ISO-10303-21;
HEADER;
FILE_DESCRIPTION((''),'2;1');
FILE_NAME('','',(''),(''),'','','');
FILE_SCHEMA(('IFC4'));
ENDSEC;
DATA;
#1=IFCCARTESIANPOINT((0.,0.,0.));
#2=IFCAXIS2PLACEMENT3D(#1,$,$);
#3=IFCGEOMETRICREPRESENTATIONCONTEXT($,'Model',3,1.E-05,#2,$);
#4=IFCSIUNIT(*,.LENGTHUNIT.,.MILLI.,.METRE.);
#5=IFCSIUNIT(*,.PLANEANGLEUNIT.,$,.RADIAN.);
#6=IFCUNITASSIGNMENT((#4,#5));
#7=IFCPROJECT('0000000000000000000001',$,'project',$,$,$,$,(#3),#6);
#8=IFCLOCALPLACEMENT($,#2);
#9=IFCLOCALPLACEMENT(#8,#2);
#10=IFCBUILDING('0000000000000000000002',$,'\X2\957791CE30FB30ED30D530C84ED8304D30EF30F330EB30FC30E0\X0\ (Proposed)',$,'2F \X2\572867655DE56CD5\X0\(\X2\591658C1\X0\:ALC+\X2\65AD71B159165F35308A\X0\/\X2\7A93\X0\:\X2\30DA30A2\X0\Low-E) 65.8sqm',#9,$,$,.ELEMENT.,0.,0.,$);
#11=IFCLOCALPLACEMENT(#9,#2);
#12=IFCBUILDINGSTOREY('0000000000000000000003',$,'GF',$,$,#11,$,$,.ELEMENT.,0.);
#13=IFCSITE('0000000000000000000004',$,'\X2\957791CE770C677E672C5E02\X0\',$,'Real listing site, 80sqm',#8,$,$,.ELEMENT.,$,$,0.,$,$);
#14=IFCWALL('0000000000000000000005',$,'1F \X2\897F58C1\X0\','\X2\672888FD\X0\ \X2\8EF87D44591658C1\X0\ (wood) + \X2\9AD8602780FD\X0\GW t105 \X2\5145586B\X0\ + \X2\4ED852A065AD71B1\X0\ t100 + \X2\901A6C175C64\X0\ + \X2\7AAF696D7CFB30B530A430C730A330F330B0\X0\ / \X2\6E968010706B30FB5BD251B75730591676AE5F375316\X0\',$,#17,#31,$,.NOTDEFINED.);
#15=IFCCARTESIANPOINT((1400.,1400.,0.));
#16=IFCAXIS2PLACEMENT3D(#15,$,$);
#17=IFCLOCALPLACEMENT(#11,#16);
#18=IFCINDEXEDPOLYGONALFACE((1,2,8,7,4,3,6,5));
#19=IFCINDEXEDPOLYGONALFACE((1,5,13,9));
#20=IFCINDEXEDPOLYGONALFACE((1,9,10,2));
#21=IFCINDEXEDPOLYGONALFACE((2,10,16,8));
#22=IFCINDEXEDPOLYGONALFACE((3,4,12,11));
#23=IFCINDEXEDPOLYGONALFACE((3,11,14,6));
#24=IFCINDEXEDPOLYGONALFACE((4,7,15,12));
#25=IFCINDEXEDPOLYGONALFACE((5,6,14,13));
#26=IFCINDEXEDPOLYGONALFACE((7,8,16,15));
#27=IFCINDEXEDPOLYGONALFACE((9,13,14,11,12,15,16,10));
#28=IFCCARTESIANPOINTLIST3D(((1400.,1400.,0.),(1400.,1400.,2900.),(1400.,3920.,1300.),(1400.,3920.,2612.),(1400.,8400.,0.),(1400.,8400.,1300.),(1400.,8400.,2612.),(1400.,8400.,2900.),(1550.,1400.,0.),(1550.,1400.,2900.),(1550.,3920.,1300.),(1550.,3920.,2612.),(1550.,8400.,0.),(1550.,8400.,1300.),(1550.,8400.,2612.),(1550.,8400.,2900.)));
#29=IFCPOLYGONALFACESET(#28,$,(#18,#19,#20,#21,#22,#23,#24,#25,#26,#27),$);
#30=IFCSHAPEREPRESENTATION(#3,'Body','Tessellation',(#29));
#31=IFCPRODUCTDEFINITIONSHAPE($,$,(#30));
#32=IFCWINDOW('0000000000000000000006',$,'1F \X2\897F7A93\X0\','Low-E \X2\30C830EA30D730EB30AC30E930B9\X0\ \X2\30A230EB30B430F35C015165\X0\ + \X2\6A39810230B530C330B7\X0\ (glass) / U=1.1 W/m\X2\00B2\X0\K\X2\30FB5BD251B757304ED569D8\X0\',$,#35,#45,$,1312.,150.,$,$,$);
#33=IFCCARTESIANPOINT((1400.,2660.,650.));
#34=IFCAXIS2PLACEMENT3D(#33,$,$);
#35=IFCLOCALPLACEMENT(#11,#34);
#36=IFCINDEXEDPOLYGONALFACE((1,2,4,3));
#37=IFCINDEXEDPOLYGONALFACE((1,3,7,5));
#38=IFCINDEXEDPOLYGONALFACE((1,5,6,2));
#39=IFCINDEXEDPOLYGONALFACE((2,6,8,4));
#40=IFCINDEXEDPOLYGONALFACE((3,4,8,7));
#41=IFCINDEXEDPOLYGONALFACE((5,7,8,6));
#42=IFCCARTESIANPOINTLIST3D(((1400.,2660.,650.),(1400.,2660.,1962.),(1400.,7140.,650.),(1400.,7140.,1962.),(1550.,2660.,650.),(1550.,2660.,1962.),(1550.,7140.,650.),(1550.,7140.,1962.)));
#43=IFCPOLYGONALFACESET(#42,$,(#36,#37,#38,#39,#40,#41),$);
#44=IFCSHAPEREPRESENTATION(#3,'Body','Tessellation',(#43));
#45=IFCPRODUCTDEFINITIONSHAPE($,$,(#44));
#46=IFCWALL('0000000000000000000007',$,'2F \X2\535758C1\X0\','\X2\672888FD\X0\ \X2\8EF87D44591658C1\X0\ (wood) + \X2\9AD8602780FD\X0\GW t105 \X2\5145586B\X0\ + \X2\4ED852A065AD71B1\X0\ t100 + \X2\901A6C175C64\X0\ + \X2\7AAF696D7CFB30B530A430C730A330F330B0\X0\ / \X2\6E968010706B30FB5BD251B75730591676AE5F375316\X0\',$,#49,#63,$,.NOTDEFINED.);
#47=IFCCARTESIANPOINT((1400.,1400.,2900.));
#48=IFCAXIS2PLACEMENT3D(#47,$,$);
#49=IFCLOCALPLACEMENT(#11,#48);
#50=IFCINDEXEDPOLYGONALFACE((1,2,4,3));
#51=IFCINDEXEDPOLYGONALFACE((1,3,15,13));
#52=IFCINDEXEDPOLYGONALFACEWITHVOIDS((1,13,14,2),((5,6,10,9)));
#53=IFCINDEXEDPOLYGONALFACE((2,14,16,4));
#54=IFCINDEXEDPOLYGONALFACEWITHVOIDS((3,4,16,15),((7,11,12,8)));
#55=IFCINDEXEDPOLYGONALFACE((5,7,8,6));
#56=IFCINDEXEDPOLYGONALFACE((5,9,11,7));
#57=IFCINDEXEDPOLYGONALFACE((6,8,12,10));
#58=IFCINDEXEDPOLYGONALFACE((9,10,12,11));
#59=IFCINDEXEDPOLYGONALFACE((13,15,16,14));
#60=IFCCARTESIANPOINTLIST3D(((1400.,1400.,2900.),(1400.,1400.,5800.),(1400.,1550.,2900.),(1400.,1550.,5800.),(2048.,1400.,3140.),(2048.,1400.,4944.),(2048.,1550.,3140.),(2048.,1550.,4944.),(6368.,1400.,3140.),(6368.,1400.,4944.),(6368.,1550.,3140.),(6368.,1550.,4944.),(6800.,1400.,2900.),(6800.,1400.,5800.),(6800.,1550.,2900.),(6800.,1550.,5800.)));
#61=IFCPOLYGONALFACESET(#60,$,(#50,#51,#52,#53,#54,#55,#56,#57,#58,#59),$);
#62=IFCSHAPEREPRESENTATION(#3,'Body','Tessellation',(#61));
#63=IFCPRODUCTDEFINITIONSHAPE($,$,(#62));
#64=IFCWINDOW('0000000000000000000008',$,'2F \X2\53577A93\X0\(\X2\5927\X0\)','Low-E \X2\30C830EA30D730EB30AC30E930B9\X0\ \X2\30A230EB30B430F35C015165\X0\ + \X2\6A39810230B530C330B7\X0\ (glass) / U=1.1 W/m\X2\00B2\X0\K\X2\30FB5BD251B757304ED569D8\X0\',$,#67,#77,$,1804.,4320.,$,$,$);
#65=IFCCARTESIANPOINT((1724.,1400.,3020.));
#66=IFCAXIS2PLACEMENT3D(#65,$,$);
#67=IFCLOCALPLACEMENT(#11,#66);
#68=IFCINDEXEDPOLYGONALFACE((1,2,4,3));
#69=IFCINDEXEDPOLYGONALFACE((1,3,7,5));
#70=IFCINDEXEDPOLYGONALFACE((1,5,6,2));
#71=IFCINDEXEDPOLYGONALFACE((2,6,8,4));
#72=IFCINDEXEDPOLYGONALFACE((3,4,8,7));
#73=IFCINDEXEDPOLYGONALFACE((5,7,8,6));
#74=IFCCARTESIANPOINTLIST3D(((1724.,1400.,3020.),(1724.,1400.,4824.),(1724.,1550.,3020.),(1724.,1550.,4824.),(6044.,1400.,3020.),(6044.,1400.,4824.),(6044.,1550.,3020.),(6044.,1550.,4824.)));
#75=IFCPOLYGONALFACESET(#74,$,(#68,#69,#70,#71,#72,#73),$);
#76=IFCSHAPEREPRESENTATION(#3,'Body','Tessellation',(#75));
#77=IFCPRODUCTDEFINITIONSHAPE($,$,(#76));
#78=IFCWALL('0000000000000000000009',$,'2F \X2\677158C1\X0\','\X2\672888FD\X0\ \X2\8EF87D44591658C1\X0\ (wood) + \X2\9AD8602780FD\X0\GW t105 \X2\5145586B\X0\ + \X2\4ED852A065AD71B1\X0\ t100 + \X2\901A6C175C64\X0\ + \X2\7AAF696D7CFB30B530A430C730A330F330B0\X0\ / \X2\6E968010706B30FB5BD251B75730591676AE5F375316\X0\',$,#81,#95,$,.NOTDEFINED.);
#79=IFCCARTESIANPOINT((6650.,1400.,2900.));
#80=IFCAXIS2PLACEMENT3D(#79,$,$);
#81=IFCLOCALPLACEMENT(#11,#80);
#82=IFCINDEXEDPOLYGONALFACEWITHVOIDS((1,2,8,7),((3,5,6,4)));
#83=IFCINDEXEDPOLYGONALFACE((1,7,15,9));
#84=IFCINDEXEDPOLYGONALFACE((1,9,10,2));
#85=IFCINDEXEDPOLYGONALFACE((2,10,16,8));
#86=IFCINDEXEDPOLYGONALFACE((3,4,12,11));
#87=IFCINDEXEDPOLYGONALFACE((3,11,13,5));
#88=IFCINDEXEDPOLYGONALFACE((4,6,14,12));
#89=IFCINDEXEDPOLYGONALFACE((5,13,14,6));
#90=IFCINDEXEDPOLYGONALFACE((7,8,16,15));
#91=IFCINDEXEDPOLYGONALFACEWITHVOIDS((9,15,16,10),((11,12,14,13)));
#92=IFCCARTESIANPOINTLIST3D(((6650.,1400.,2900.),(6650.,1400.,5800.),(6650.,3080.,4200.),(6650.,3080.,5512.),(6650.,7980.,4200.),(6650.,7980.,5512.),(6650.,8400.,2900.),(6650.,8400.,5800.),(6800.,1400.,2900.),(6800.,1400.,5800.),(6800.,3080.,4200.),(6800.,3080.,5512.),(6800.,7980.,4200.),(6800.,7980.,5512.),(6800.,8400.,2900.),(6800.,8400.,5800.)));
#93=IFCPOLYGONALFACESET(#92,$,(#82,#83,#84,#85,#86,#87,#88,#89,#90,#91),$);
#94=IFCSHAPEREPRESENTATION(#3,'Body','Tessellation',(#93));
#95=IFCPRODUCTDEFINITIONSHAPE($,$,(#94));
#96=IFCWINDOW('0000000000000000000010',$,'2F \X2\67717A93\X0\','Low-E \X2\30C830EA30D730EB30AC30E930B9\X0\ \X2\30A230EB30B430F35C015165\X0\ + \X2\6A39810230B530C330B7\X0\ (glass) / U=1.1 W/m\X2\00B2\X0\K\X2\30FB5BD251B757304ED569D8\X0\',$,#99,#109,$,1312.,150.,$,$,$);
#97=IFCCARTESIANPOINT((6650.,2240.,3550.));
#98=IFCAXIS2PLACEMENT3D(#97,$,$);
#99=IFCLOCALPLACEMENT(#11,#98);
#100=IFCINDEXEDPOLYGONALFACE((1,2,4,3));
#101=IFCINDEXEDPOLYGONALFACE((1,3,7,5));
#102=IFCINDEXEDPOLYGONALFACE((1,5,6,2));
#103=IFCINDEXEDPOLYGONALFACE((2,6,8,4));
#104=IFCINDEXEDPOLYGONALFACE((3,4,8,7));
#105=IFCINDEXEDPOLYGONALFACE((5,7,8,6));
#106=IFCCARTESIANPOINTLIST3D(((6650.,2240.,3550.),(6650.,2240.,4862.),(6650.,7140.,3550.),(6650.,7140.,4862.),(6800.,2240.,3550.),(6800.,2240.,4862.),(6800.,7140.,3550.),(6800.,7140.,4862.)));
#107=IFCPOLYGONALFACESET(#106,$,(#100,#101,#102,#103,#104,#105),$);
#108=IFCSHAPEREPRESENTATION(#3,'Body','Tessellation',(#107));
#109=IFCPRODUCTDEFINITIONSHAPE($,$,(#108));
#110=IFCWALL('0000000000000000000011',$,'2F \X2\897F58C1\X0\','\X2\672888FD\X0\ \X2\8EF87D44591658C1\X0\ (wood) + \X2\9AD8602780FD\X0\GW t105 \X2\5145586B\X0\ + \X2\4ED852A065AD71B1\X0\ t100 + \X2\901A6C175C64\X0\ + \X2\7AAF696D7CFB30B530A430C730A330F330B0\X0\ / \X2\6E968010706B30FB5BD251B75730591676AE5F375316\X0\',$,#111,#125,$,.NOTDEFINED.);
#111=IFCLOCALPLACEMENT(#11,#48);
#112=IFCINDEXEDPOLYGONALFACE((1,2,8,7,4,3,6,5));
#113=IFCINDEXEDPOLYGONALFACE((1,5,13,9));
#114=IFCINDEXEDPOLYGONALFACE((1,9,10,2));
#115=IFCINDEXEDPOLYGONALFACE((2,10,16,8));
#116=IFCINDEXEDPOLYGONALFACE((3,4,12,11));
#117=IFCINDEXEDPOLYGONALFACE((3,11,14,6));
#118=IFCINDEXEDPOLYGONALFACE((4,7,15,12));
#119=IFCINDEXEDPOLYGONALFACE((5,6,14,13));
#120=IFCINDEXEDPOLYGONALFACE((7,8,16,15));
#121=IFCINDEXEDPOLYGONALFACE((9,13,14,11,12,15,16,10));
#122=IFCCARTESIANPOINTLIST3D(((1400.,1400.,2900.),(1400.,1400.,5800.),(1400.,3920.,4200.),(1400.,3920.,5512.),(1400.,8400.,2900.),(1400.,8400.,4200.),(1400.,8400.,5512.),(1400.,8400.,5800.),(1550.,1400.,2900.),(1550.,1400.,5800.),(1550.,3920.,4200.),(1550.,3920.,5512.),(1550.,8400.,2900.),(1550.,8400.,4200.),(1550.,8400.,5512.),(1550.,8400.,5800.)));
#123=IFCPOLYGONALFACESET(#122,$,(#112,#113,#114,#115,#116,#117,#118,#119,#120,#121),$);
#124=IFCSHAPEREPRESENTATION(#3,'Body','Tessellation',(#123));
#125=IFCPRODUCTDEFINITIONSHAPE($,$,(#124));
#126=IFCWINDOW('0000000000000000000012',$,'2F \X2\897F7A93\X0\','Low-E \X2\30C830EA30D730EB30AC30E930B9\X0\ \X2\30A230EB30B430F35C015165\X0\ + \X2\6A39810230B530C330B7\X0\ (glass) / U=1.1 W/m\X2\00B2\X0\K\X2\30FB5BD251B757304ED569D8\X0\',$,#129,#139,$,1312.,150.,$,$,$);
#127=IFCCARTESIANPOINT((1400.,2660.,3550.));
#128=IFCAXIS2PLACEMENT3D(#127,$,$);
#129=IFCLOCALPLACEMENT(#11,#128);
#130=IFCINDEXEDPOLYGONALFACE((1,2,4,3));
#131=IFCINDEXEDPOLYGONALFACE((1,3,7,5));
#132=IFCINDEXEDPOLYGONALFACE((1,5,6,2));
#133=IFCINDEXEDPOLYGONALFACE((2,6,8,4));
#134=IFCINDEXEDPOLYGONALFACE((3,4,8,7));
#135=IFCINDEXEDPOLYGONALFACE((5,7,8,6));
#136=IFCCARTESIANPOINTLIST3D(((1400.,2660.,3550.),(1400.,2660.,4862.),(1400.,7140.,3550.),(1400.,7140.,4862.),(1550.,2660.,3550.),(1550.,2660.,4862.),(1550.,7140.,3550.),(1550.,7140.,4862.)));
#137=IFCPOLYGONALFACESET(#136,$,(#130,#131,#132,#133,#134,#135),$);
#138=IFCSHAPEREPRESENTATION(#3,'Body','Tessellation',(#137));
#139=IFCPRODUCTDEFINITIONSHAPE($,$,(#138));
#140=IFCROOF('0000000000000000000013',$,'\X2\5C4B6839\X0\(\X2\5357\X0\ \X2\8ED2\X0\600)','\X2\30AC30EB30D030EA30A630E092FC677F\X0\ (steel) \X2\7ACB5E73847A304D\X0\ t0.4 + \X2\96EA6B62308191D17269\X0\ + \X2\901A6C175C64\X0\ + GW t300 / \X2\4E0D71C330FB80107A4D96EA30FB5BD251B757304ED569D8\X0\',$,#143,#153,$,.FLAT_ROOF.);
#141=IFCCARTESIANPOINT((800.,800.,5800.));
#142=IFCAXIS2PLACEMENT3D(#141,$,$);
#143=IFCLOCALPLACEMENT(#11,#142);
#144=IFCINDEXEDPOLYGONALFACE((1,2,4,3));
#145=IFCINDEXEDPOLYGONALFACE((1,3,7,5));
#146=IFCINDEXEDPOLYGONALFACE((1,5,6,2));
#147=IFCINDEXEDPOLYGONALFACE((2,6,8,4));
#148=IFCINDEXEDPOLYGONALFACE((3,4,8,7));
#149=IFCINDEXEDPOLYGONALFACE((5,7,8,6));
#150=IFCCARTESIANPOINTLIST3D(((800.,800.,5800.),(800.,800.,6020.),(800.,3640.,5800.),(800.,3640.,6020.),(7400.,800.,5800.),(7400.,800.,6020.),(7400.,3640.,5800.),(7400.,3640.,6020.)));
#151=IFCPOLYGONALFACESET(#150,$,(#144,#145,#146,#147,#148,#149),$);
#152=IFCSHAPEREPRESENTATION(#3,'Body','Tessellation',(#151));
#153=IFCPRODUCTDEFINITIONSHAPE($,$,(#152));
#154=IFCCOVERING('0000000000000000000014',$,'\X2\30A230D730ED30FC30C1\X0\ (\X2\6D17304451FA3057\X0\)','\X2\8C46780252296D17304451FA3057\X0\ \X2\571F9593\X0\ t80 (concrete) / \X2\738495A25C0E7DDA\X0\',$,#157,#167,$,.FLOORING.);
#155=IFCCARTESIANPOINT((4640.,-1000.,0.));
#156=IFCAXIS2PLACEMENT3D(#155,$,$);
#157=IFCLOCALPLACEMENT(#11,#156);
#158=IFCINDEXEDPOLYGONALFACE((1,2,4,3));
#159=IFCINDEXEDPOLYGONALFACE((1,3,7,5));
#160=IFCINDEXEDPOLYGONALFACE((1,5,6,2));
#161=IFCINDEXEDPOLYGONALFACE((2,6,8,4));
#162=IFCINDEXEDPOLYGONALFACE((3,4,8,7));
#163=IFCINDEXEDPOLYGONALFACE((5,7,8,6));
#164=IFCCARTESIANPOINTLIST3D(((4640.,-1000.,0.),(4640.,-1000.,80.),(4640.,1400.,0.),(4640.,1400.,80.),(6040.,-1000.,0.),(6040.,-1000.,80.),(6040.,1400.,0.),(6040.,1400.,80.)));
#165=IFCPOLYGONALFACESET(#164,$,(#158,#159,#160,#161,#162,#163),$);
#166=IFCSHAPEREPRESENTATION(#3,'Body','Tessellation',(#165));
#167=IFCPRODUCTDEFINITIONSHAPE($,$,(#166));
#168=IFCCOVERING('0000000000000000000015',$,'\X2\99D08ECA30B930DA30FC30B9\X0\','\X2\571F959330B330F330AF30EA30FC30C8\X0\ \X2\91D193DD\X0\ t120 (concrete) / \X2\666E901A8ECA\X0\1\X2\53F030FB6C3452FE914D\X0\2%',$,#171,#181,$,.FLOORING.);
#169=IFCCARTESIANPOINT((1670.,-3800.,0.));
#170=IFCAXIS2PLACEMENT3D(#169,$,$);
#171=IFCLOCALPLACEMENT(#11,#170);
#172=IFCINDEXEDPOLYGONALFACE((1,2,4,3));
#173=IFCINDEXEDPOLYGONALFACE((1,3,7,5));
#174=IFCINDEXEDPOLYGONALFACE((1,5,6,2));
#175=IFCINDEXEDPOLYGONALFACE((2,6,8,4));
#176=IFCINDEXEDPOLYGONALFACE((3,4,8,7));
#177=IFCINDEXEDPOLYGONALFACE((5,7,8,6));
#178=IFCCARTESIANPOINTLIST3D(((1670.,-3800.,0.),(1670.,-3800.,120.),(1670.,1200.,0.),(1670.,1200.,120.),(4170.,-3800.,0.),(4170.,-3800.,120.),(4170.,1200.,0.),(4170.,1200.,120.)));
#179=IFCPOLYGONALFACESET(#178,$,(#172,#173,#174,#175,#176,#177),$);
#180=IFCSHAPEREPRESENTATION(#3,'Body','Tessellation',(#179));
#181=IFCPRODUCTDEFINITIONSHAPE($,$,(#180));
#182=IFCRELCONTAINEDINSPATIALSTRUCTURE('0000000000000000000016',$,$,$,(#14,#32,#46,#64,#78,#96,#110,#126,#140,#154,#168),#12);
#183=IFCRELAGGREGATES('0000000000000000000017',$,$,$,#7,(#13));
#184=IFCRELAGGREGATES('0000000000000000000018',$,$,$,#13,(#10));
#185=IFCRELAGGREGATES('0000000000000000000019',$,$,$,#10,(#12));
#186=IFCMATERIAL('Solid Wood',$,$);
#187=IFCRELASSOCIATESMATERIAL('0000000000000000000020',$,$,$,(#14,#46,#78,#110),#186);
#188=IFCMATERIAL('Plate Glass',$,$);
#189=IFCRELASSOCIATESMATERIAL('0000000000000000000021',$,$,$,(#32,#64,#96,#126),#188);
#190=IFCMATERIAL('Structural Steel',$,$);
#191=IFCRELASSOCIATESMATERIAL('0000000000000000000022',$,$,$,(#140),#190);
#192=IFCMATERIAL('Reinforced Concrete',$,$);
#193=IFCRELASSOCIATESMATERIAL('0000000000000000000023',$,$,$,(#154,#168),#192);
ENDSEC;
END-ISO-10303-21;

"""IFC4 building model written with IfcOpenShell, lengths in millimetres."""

from ifc_helpers import new_model, si_unit, frame, frame_2d, origin, place, context, project, spatial, rectangle, extrude, material, element, fill, save


model = new_model("IFC4")

# Units and contexts
model_context = context("Model", 3, precision=1e-05, world=origin())
ifc_project = project(units=[si_unit("LENGTHUNIT", "METRE", prefix="MILLI"), si_unit("PLANEANGLEUNIT", "RADIAN")], contexts=[model_context])

# Site, building, storey
site_placement = place(None, origin())
site = spatial("IfcSite", under=ifc_project, at=site_placement, Name="長野県松本市", ObjectType="Real listing site, 80sqm", CompositionType="ELEMENT", RefElevation=0.0)
building_placement = place(site_placement, origin())
building = spatial("IfcBuilding", under=site, at=building_placement, Name="長野・ロフト付きワンルーム (Proposed)", ObjectType="2F 在来工法(外壁:ALC+断熱外張り/窓:ペアLow-E) 65.8sqm", CompositionType="ELEMENT", ElevationOfRefHeight=0.0, ElevationOfTerrain=0.0)
storey_placement = place(building_placement, origin())
storey = spatial("IfcBuildingStorey", under=building, at=storey_placement, Name="GF", CompositionType="ELEMENT", Elevation=0.0)

# Shared definitions
ifc_material_1 = material(Name="Solid Wood")

# Shared definitions
ifc_material_2 = material(Name="Reinforced Concrete")

# Shared definitions
ifc_material_3 = material(Name="Plate Glass")

# Walls, openings, windows
wall_1_placement = place(storey_placement, frame((1400.0, 1400.0, 0.0)))
wall_1 = element("IfcWall", 1, at=wall_1_placement, inside=storey, material=ifc_material_1, Name="1F 西壁", Description="木製 軸組外壁 (wood) + 高性能GW t105 充填 + 付加断熱 t100 + 通気層 + 窯業系サイディング / 準耐火・寒冷地外皮強化", PredefinedType="NOTDEFINED", context=model_context, shape_type="SweptSolid", body=[
    extrude(rectangle(XDim=150.0, YDim=7000.0, at=frame_2d((75.0, 3500.0))), frame((1400.0, 1400.0, 0.0)), (0.0, 0.0, 1.0), 2900.0),
])
opening_1_placement = place(storey_placement, frame((1400.0, 2660.0, 650.0)))
opening_1 = element("IfcOpeningElement", 2, at=opening_1_placement, cuts=wall_1, PredefinedType="NOTDEFINED", context=model_context, shape_type="SweptSolid", body=[
    extrude(rectangle(XDim=150.0, YDim=4480.0, at=frame_2d((75.0, 2240.0))), frame((1400.0, 2660.0, 650.0)), (0.0, 0.0, 1.0), 1312.0),
])
window_1_placement = place(storey_placement, frame((1400.0, 2660.0, 650.0)))
window_1 = element("IfcWindow", 3, at=window_1_placement, inside=storey, material=ifc_material_3, Name="1F 西窓", Description="Low-E トリプルガラス アルゴン封入 + 樹脂サッシ (glass) / U=1.1 W/m²K・寒冷地仕様", OverallHeight=1312.0, OverallWidth=150.0, context=model_context, shape_type="SweptSolid", body=[
    extrude(rectangle(XDim=150.0, YDim=4480.0, at=frame_2d((75.0, 2240.0))), frame((1400.0, 2660.0, 650.0)), (0.0, 0.0, 1.0), 1312.0),
])
fill(opening_1, window_1)
wall_2_placement = place(storey_placement, frame((1400.0, 1400.0, 2900.0)))
wall_2 = element("IfcWall", 4, at=wall_2_placement, inside=storey, material=ifc_material_1, Name="2F 南壁", Description="木製 軸組外壁 (wood) + 高性能GW t105 充填 + 付加断熱 t100 + 通気層 + 窯業系サイディング / 準耐火・寒冷地外皮強化", PredefinedType="NOTDEFINED", context=model_context, shape_type="SweptSolid", body=[
    extrude(rectangle(XDim=5400.0, YDim=150.0, at=frame_2d((2700.0, 75.0))), frame((1400.0, 1400.0, 2900.0)), (0.0, 0.0, 1.0), 2900.0),
])
opening_2_placement = place(storey_placement, frame((1724.0, 1400.0, 3020.0)))
opening_2 = element("IfcOpeningElement", 5, at=opening_2_placement, cuts=wall_2, PredefinedType="NOTDEFINED", context=model_context, shape_type="SweptSolid", body=[
    extrude(rectangle(XDim=4320.0, YDim=150.0, at=frame_2d((2160.0, 75.0))), frame((1724.0, 1400.0, 3020.0)), (0.0, 0.0, 1.0), 1804.0),
])
window_2_placement = place(storey_placement, frame((1724.0, 1400.0, 3020.0)))
window_2 = element("IfcWindow", 6, at=window_2_placement, inside=storey, material=ifc_material_3, Name="2F 南窓(大)", Description="Low-E トリプルガラス アルゴン封入 + 樹脂サッシ (glass) / U=1.1 W/m²K・寒冷地仕様", OverallHeight=1804.0, OverallWidth=4320.0, context=model_context, shape_type="SweptSolid", body=[
    extrude(rectangle(XDim=4320.0, YDim=150.0, at=frame_2d((2160.0, 75.0))), frame((1724.0, 1400.0, 3020.0)), (0.0, 0.0, 1.0), 1804.0),
])
fill(opening_2, window_2)
wall_3_placement = place(storey_placement, frame((6650.0, 1400.0, 2900.0)))
wall_3 = element("IfcWall", 7, at=wall_3_placement, inside=storey, material=ifc_material_1, Name="2F 東壁", Description="木製 軸組外壁 (wood) + 高性能GW t105 充填 + 付加断熱 t100 + 通気層 + 窯業系サイディング / 準耐火・寒冷地外皮強化", PredefinedType="NOTDEFINED", context=model_context, shape_type="SweptSolid", body=[
    extrude(rectangle(XDim=150.0, YDim=7000.0, at=frame_2d((75.0, 3500.0))), frame((6650.0, 1400.0, 2900.0)), (0.0, 0.0, 1.0), 2900.0),
])
opening_3_placement = place(storey_placement, frame((6650.0, 2240.0, 3550.0)))
opening_3 = element("IfcOpeningElement", 8, at=opening_3_placement, cuts=wall_3, PredefinedType="NOTDEFINED", context=model_context, shape_type="SweptSolid", body=[
    extrude(rectangle(XDim=150.0, YDim=4900.0, at=frame_2d((75.0, 2450.0))), frame((6650.0, 2240.0, 3550.0)), (0.0, 0.0, 1.0), 1312.0),
])
window_3_placement = place(storey_placement, frame((6650.0, 2240.0, 3550.0)))
window_3 = element("IfcWindow", 9, at=window_3_placement, inside=storey, material=ifc_material_3, Name="2F 東窓", Description="Low-E トリプルガラス アルゴン封入 + 樹脂サッシ (glass) / U=1.1 W/m²K・寒冷地仕様", OverallHeight=1312.0, OverallWidth=150.0, context=model_context, shape_type="SweptSolid", body=[
    extrude(rectangle(XDim=150.0, YDim=4900.0, at=frame_2d((75.0, 2450.0))), frame((6650.0, 2240.0, 3550.0)), (0.0, 0.0, 1.0), 1312.0),
])
fill(opening_3, window_3)
wall_4_placement = place(storey_placement, frame((1400.0, 1400.0, 2900.0)))
wall_4 = element("IfcWall", 10, at=wall_4_placement, inside=storey, material=ifc_material_1, Name="2F 西壁", Description="木製 軸組外壁 (wood) + 高性能GW t105 充填 + 付加断熱 t100 + 通気層 + 窯業系サイディング / 準耐火・寒冷地外皮強化", PredefinedType="NOTDEFINED", context=model_context, shape_type="SweptSolid", body=[
    extrude(rectangle(XDim=150.0, YDim=7000.0, at=frame_2d((75.0, 3500.0))), frame((1400.0, 1400.0, 2900.0)), (0.0, 0.0, 1.0), 2900.0),
])
opening_4_placement = place(storey_placement, frame((1400.0, 2660.0, 3550.0)))
opening_4 = element("IfcOpeningElement", 11, at=opening_4_placement, cuts=wall_4, PredefinedType="NOTDEFINED", context=model_context, shape_type="SweptSolid", body=[
    extrude(rectangle(XDim=150.0, YDim=4480.0, at=frame_2d((75.0, 2240.0))), frame((1400.0, 2660.0, 3550.0)), (0.0, 0.0, 1.0), 1312.0),
])
window_4_placement = place(storey_placement, frame((1400.0, 2660.0, 3550.0)))
window_4 = element("IfcWindow", 12, at=window_4_placement, inside=storey, material=ifc_material_3, Name="2F 西窓", Description="Low-E トリプルガラス アルゴン封入 + 樹脂サッシ (glass) / U=1.1 W/m²K・寒冷地仕様", OverallHeight=1312.0, OverallWidth=150.0, context=model_context, shape_type="SweptSolid", body=[
    extrude(rectangle(XDim=150.0, YDim=4480.0, at=frame_2d((75.0, 2240.0))), frame((1400.0, 2660.0, 3550.0)), (0.0, 0.0, 1.0), 1312.0),
])
fill(opening_4, window_4)

# Roof
ifc_material_4 = material(Name="Structural Steel")
for number, where, name in (
    (13, (800.0, 800.0, 5800.0), "屋根(南 軒600)"),
):
    element("IfcRoof", number, at=place(storey_placement, frame(where)), inside=storey, material=ifc_material_4, Name=name, Description="ガルバリウム鋼板 (steel) 立平葺き t0.4 + 雪止め金物 + 通気層 + GW t300 / 不燃・耐積雪・寒冷地仕様", PredefinedType="FLAT_ROOF", context=model_context, shape_type="SweptSolid", body=[
        extrude(rectangle(XDim=6600.0, YDim=2840.0, at=frame_2d((3300.0, 1420.0))), frame((800.0, 800.0, 5800.0)), (0.0, 0.0, 1.0), 220.0),
    ])

# Coverings
covering_1_placement = place(storey_placement, frame((4640.0, -1000.0, 0.0)))
element("IfcCovering", 14, at=covering_1_placement, inside=storey, material=ifc_material_2, Name="アプローチ (洗い出し)", Description="豆砂利洗い出し 土間 t80 (concrete) / 玄関導線", PredefinedType="FLOORING", context=model_context, shape_type="SweptSolid", body=[
    extrude(rectangle(XDim=1400.0, YDim=2400.0, at=frame_2d((700.0, 1200.0))), frame((4640.0, -1000.0, 0.0)), (0.0, 0.0, 1.0), 80.0),
])
covering_2_placement = place(storey_placement, frame((1670.0, -3800.0, 0.0)))
element("IfcCovering", 15, at=covering_2_placement, inside=storey, material=ifc_material_2, Name="駐車スペース", Description="土間コンクリート 金鏝 t120 (concrete) / 普通車1台・水勾配2%", PredefinedType="FLOORING", context=model_context, shape_type="SweptSolid", body=[
    extrude(rectangle(XDim=2500.0, YDim=5000.0, at=frame_2d((1250.0, 2500.0))), frame((1670.0, -3800.0, 0.0)), (0.0, 0.0, 1.0), 120.0),
])

save(model, "model.ifc")
